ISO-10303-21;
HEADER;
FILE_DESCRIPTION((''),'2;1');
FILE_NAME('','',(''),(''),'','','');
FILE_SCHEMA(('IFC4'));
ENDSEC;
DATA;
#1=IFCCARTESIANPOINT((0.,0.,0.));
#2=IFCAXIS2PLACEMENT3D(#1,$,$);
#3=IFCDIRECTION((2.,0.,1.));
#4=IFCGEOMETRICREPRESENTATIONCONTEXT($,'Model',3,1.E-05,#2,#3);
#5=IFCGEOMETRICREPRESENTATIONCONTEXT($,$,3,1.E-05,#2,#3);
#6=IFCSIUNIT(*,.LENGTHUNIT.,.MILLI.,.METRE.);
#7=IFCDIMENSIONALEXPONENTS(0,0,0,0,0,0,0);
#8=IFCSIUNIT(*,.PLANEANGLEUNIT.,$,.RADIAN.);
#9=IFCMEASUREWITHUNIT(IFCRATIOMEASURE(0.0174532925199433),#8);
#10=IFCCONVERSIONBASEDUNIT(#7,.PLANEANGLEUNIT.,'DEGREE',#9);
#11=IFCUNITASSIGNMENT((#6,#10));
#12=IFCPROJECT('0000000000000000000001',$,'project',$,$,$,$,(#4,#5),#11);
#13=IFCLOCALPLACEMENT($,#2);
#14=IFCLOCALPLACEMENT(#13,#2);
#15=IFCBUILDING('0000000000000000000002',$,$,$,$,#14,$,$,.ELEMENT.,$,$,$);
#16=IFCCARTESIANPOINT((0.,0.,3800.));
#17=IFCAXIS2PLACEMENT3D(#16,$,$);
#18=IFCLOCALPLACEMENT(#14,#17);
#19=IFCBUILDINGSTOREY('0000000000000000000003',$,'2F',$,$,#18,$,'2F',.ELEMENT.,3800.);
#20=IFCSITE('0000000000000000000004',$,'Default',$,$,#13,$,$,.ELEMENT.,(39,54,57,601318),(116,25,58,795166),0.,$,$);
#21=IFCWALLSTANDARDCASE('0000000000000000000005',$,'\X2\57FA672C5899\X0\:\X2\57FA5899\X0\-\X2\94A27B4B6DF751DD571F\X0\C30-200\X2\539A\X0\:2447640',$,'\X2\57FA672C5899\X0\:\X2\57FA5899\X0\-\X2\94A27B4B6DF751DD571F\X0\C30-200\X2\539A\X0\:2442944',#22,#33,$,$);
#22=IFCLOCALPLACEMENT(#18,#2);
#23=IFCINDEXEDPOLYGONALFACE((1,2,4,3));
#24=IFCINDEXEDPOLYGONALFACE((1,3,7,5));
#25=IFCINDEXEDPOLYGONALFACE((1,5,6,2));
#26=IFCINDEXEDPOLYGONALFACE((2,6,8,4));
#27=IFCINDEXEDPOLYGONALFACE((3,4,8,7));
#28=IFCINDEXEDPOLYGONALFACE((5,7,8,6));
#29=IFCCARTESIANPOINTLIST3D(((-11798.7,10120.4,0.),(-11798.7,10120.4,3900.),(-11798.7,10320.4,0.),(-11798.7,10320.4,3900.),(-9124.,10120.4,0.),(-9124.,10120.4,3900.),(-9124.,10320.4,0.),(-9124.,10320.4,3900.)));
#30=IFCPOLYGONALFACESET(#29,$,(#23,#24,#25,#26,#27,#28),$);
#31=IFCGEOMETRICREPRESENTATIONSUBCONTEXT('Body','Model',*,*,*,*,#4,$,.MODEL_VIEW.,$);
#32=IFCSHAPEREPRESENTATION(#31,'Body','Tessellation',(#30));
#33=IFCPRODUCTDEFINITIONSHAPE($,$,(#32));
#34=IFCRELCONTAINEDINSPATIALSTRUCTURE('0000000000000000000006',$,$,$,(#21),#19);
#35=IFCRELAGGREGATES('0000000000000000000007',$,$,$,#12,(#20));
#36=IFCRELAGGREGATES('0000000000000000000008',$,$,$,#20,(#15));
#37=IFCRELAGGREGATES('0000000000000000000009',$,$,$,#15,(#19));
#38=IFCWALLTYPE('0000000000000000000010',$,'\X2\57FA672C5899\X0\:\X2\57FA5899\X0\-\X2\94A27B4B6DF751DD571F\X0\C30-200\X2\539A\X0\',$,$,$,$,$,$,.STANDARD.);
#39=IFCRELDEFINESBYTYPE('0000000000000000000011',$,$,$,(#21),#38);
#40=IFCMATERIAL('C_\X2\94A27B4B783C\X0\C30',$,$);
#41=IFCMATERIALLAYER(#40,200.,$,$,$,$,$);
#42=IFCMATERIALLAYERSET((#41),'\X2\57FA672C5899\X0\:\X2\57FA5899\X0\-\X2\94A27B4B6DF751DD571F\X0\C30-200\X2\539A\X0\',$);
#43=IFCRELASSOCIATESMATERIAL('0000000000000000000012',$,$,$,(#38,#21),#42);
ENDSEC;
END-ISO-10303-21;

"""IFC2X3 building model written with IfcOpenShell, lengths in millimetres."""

from ifc_helpers import new_model, entity, si_unit, converted_unit, direction, frame, frame_2d, origin, place, context, subcontext, project, spatial, rectangle, extrude, material, layer, layer_set, layer_usage, type_object, element, save


model = new_model("IFC2X3")

# Units and contexts
model_context = context("Model", 3, precision=1e-05, world=origin(), true_north=direction((2.0, 0.0, 1.0)))
context_of_model = context(None, 3, precision=1e-05, world=origin(), true_north=direction((2.0, 0.0, 1.0)))
body_context = subcontext(model_context, "Body", "Model", "MODEL_VIEW")
ifc_project = project(units=[si_unit("LENGTHUNIT", "METRE", prefix="MILLI"), converted_unit("PLANEANGLEUNIT", "DEGREE", entity("IfcRatioMeasure", 0.0174532925199433), si_unit("PLANEANGLEUNIT", "RADIAN"), dimensions=[0, 0, 0, 0, 0, 0, 0])], contexts=[model_context, context_of_model])

# Site, building, storey
site_placement = place(None, origin())
site = spatial("IfcSite", under=ifc_project, at=site_placement, Name="Default", CompositionType="ELEMENT", RefLatitude=(39, 54, 57, 601318), RefLongitude=(116, 25, 58, 795166), RefElevation=0.0)
building_placement = place(site_placement, origin())
building = spatial("IfcBuilding", under=site, at=building_placement, CompositionType="ELEMENT")
storey_placement = place(building_placement, frame((0.0, 0.0, 3800.0)))
storey = spatial("IfcBuildingStorey", under=building, at=storey_placement, Name="2F", LongName="2F", CompositionType="ELEMENT", Elevation=3800.0)

# Shared definitions
ifc_material_1 = material(Name="C_钢筋砼C30")

# Wall
ifc_layer = layer(ifc_material_1, 200.0)
ifc_layer_set = layer_set([ifc_layer], Name="基本墙:基墙-钢筋混凝土C30-200厚")
ifc_layer_usage = layer_usage(ifc_layer_set, "AXIS2", "POSITIVE", -100.0)
wall_type = type_object("IfcWallType", Name="基本墙:基墙-钢筋混凝土C30-200厚", PredefinedType="STANDARD", material=ifc_layer_set)
wall_placement = place(storey_placement, frame((-9124.0, 10220.4, 0.0), z_axis=(0.0, 0.0, 1.0), x_axis=(-1.0, 0.0, 0.0)))
element("IfcWallStandardCase", 1, at=wall_placement, inside=storey, type_object=wall_type, material=ifc_layer_usage, Name="基本墙:基墙-钢筋混凝土C30-200厚:2447640", ObjectType="基本墙:基墙-钢筋混凝土C30-200厚:2442944", context=body_context, shape_type="SweptSolid", body=[
    extrude(rectangle(XDim=2674.6, YDim=200.0, at=frame_2d((1337.3, 0.0), x_axis=(-1.0, 0.0))), origin(), (0.0, 0.0, 1.0), 3900.0),
])

save(model, "model.ifc")
